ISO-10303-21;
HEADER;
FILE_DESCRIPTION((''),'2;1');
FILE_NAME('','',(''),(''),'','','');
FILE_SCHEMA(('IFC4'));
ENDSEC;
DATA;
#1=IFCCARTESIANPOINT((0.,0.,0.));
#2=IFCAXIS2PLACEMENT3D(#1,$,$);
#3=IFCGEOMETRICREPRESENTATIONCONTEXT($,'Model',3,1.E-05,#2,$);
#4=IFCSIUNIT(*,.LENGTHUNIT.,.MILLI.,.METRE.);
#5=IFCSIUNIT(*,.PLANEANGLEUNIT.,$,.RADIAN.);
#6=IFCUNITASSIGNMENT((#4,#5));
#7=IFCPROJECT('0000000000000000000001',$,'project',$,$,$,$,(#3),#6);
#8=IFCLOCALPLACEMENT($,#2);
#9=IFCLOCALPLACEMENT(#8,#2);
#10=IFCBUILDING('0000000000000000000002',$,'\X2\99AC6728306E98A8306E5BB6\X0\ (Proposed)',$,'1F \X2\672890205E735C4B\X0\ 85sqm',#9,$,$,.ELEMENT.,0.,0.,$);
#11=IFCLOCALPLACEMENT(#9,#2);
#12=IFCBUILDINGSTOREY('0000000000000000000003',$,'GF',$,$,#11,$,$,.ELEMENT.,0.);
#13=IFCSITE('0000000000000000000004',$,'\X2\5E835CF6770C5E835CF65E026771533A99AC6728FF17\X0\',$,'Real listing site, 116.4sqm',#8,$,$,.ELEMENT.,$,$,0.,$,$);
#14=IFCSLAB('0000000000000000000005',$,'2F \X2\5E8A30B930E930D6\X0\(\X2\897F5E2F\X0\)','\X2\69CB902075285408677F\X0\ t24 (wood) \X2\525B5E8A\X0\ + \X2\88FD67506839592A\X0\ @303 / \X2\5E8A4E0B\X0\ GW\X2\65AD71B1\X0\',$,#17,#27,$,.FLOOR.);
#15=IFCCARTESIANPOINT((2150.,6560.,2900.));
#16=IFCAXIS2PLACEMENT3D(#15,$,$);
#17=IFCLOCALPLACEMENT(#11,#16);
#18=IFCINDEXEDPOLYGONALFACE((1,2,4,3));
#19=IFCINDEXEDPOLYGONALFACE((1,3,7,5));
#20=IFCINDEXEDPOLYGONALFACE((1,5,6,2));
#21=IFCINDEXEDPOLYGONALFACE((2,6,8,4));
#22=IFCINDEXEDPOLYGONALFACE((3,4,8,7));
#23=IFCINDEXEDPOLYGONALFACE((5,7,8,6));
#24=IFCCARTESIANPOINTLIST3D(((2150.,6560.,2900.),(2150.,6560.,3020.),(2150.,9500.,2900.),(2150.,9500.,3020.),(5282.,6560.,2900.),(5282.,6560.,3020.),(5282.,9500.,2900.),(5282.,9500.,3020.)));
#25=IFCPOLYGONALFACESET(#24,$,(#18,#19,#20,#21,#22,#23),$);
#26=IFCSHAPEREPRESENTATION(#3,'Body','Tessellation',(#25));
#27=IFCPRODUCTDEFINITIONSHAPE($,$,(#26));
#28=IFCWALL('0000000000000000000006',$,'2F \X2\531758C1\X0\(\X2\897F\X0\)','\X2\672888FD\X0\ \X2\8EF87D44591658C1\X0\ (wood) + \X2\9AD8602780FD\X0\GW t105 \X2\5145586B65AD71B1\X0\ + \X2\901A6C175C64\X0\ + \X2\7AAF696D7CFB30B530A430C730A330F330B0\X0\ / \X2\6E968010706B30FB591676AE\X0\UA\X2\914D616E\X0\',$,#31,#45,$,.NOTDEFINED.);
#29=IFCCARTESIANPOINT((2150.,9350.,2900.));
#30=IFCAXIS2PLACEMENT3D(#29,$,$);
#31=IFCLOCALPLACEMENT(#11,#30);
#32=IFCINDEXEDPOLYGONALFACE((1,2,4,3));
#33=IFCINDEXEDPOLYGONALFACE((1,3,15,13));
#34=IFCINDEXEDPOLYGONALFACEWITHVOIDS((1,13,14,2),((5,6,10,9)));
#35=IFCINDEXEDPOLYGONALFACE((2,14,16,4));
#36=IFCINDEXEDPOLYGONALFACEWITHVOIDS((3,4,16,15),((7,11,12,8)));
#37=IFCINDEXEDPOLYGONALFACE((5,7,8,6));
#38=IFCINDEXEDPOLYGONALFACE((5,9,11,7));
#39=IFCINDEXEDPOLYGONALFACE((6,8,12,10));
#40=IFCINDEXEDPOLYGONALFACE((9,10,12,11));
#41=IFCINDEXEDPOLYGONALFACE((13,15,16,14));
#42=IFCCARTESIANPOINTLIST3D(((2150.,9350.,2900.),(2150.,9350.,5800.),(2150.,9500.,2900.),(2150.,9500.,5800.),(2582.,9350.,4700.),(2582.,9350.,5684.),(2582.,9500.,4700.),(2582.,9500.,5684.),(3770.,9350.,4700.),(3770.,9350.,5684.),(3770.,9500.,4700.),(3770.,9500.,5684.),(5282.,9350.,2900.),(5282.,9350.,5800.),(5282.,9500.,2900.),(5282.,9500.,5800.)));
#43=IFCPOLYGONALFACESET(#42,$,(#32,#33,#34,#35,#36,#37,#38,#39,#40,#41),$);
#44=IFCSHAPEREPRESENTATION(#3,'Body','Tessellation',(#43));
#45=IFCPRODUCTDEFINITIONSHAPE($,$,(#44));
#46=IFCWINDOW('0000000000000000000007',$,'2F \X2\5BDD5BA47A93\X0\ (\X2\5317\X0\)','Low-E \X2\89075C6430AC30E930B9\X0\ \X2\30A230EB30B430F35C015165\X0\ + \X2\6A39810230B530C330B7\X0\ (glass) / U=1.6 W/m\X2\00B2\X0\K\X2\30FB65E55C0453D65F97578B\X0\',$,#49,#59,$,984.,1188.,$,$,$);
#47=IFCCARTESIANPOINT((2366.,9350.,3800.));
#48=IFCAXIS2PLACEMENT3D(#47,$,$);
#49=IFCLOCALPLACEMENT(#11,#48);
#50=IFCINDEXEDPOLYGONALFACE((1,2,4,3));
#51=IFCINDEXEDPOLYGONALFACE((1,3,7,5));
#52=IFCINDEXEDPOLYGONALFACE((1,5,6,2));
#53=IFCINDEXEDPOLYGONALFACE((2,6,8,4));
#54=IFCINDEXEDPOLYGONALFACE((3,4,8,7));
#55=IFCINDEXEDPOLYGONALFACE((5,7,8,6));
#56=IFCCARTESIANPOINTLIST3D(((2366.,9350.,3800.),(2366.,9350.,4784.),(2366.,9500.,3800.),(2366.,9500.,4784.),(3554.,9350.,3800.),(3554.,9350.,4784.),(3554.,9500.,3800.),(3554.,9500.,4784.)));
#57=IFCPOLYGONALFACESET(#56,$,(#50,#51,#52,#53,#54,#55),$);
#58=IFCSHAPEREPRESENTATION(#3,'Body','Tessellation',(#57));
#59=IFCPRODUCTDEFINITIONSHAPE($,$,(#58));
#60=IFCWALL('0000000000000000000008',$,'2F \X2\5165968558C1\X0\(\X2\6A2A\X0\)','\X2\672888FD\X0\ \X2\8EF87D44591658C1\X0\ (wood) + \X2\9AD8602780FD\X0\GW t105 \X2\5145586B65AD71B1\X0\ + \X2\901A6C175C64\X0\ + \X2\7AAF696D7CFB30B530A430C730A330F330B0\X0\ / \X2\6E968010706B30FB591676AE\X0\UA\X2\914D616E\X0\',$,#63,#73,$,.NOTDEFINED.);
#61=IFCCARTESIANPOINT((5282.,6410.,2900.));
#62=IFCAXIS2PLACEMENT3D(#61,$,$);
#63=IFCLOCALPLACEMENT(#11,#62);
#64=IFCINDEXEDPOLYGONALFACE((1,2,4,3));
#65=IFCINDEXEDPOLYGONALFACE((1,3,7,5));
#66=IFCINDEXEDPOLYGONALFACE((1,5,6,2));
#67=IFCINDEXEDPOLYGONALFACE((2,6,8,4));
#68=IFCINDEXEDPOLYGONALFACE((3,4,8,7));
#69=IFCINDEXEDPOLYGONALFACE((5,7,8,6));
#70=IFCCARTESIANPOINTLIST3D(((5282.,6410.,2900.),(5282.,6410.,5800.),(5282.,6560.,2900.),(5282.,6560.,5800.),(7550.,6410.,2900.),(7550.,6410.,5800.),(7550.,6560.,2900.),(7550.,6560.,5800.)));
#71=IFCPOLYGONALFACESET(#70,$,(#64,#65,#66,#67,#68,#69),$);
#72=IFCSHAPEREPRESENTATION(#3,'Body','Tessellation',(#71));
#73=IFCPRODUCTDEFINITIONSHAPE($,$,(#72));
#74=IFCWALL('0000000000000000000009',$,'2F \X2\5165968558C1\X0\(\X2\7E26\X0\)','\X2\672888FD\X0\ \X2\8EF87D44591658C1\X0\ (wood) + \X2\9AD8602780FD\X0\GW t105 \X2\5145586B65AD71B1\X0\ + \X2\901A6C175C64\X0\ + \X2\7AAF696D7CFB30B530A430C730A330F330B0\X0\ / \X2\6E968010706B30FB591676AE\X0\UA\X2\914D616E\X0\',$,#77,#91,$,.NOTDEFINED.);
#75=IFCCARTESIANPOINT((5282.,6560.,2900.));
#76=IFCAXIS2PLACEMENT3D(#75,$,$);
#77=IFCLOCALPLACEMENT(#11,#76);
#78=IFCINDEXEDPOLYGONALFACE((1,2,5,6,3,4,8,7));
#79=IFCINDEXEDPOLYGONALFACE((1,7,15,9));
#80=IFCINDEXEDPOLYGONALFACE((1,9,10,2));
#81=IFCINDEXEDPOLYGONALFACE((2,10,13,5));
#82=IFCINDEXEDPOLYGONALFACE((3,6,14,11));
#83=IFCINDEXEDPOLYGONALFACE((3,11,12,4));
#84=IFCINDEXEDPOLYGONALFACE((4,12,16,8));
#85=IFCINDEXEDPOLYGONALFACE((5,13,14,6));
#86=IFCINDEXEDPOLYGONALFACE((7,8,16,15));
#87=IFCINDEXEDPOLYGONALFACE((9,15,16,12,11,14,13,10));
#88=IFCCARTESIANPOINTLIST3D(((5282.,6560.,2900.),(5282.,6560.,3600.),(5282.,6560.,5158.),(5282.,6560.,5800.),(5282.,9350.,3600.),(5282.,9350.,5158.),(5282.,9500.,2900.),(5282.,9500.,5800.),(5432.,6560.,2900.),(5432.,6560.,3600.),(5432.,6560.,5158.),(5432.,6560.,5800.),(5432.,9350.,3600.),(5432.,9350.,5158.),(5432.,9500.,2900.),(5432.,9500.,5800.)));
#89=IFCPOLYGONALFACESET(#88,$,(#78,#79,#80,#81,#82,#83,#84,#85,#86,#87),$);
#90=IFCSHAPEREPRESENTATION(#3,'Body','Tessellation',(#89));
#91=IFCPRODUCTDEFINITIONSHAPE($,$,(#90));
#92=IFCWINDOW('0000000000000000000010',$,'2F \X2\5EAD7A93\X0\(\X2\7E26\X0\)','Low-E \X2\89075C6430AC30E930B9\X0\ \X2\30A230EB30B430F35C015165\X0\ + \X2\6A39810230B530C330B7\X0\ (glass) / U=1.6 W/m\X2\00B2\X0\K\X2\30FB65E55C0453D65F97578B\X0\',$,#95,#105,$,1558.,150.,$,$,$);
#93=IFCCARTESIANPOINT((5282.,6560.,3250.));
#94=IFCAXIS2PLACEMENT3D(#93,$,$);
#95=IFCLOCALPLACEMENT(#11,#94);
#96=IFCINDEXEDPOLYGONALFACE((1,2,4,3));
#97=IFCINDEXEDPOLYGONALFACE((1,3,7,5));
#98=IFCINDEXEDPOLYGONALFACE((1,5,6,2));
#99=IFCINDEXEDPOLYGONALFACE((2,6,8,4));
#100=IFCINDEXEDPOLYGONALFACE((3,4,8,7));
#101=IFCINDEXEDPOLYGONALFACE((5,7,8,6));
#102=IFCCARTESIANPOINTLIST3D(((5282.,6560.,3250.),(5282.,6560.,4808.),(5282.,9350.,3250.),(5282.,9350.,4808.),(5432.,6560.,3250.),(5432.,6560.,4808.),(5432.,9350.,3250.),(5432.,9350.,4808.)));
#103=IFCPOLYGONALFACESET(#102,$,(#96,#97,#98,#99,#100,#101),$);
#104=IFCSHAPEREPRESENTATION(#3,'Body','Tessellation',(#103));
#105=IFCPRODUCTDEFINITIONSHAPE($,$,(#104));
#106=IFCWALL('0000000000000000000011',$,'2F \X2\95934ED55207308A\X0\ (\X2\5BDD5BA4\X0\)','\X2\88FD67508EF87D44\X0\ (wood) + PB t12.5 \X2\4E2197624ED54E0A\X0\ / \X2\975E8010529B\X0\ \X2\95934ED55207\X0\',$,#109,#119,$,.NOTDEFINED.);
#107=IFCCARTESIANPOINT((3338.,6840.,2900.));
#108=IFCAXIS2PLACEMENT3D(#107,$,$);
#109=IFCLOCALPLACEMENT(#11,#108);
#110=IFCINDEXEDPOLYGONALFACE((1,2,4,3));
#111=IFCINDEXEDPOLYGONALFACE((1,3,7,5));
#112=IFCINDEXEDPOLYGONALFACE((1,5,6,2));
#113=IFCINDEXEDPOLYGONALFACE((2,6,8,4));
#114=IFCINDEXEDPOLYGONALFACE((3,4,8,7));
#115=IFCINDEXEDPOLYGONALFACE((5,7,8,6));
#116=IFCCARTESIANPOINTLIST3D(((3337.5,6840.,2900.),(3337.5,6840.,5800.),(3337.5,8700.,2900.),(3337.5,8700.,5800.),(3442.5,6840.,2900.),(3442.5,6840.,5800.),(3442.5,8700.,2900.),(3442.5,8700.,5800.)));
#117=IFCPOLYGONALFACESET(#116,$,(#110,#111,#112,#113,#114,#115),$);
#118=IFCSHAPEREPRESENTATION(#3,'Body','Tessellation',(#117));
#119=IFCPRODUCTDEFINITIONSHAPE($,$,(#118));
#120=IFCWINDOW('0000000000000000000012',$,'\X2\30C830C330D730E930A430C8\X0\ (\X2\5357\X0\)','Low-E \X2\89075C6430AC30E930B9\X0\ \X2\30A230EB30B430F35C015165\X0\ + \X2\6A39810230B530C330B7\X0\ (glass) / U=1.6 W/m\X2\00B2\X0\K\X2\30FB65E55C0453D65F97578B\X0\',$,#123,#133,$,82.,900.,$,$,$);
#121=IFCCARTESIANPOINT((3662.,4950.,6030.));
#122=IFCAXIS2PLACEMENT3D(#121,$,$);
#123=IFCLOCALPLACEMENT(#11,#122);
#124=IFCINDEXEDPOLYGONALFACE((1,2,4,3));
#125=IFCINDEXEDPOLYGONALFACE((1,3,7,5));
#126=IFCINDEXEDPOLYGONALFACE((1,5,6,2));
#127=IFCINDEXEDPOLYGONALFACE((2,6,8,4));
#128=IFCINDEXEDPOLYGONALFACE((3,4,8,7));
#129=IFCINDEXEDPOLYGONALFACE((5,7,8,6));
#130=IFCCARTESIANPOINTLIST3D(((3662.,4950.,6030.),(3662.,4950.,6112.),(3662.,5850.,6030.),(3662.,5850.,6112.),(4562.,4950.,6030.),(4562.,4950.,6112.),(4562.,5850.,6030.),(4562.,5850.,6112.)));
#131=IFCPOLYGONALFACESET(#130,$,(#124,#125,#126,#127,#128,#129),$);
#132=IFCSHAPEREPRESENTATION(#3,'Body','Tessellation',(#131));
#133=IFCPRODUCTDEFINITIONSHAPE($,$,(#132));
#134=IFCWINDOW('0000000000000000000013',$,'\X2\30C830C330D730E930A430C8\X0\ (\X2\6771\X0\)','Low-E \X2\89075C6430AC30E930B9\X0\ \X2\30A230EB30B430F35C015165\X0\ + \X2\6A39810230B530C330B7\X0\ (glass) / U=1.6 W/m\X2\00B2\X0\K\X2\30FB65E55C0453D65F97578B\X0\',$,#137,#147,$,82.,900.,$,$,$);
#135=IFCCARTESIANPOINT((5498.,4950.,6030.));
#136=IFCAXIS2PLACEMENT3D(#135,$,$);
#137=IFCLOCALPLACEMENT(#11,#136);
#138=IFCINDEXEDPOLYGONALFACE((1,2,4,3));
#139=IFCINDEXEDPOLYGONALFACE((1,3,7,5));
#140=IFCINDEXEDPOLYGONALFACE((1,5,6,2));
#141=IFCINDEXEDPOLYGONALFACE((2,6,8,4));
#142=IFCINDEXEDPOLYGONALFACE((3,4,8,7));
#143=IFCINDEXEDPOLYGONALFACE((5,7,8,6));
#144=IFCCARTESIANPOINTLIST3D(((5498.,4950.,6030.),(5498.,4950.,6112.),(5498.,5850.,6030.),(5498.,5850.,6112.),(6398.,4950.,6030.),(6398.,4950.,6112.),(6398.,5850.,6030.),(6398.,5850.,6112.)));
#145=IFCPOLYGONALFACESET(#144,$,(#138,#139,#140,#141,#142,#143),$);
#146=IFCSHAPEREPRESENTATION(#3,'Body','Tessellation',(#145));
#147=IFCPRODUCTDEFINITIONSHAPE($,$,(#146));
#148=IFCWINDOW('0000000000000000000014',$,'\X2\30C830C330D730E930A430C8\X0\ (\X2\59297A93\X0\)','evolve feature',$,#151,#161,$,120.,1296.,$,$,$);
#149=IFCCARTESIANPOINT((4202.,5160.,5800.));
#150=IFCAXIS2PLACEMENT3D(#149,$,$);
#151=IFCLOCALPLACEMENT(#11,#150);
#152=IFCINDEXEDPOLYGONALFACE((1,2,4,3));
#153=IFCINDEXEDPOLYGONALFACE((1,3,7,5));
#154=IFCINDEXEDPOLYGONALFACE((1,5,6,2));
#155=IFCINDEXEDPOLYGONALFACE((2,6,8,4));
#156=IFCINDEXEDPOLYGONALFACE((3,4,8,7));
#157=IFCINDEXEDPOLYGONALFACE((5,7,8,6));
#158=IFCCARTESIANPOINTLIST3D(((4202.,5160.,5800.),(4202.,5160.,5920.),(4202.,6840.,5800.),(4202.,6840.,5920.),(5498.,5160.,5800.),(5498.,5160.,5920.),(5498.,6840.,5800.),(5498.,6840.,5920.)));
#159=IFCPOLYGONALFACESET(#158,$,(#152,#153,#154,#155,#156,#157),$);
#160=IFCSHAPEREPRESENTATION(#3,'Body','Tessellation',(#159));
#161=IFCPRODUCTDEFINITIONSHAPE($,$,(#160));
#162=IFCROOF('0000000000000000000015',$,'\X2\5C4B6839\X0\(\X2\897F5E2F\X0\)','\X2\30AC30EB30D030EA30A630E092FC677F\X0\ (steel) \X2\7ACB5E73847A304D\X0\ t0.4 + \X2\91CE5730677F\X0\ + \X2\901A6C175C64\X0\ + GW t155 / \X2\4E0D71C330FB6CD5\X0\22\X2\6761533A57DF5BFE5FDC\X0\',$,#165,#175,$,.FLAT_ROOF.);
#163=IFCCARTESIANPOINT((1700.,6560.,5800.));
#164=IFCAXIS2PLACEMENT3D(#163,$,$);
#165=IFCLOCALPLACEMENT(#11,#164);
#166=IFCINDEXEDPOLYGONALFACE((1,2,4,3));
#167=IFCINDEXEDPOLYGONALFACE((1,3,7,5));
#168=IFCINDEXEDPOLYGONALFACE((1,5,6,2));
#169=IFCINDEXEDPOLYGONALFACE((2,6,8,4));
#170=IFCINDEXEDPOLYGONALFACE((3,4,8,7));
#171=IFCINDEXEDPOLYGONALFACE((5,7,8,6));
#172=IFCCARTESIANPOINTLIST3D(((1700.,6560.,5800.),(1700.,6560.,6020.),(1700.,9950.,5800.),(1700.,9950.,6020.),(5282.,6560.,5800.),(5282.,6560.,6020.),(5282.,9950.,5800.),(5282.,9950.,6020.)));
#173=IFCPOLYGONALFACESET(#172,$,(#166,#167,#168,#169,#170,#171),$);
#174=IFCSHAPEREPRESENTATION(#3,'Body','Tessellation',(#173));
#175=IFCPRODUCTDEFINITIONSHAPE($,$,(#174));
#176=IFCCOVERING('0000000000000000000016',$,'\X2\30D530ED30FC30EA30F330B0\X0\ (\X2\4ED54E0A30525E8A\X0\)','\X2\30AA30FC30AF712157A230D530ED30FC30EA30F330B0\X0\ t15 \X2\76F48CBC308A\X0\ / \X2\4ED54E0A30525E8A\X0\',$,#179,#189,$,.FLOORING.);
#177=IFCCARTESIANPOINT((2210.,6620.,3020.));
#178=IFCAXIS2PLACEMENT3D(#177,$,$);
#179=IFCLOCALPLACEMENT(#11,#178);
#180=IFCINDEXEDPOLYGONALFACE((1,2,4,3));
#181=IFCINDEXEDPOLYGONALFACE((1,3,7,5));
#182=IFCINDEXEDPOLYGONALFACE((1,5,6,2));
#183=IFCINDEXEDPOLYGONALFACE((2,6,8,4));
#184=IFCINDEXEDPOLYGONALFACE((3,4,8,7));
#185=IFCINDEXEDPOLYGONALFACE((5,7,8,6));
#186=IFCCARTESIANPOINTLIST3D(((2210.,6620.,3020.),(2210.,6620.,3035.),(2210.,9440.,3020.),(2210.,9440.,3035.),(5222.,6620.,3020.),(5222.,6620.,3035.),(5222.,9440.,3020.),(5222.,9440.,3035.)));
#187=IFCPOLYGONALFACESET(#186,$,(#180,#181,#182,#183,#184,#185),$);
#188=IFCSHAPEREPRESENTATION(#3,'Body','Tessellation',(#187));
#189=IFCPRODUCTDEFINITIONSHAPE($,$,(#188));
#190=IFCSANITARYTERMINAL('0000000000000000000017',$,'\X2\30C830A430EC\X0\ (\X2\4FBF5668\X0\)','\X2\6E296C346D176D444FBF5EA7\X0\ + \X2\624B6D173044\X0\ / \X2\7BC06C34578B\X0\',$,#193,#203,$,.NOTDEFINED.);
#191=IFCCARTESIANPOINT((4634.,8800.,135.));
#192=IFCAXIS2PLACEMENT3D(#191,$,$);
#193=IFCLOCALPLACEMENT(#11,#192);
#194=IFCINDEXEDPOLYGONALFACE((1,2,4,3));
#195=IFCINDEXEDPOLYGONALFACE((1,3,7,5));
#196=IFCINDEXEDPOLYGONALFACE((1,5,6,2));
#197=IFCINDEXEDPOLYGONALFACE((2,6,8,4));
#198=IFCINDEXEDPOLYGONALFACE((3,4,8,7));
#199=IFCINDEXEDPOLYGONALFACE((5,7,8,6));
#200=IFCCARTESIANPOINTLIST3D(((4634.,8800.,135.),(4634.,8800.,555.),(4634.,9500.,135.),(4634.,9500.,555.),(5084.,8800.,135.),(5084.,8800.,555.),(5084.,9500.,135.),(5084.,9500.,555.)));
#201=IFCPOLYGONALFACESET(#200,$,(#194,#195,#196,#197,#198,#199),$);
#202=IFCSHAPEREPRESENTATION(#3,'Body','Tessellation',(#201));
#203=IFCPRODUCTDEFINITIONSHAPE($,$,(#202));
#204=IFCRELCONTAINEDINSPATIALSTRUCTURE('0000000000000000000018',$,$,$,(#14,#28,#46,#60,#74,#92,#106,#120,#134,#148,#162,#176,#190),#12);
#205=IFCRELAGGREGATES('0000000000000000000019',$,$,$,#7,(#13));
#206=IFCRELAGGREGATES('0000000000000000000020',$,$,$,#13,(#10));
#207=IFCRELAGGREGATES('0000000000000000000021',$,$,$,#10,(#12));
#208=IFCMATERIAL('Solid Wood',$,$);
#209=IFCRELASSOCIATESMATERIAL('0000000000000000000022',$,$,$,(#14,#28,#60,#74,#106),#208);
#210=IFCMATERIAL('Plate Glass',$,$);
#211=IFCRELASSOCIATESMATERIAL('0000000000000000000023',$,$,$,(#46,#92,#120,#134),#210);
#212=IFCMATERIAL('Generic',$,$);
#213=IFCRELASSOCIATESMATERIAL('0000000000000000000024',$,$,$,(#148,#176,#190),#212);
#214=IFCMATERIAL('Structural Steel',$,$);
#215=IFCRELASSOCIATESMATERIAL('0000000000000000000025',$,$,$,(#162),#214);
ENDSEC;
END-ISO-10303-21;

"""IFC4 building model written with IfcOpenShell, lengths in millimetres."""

from ifc_helpers import new_model, si_unit, frame, frame_2d, origin, place, context, project, spatial, rectangle, extrude, material, element, fill, save


model = new_model("IFC4")

# Units and contexts
model_context = context("Model", 3, precision=1e-05, world=origin())
ifc_project = project(units=[si_unit("LENGTHUNIT", "METRE", prefix="MILLI"), si_unit("PLANEANGLEUNIT", "RADIAN")], contexts=[model_context])

# Site, building, storey
site_placement = place(None, origin())
site = spatial("IfcSite", under=ifc_project, at=site_placement, Name="広島県広島市東区馬木７", ObjectType="Real listing site, 116.4sqm", CompositionType="ELEMENT", RefElevation=0.0)
building_placement = place(site_placement, origin())
building = spatial("IfcBuilding", under=site, at=building_placement, Name="馬木の風の家 (Proposed)", ObjectType="1F 木造平屋 85sqm", CompositionType="ELEMENT", ElevationOfRefHeight=0.0, ElevationOfTerrain=0.0)
storey_placement = place(building_placement, origin())
storey = spatial("IfcBuildingStorey", under=building, at=storey_placement, Name="GF", CompositionType="ELEMENT", Elevation=0.0)

# Slab
ifc_material_1 = material(Name="Solid Wood")
slab_placement = place(storey_placement, frame((2150.0, 6560.0, 2900.0)))
element("IfcSlab", 1, at=slab_placement, inside=storey, material=ifc_material_1, Name="2F 床スラブ(西帯)", Description="構造用合板 t24 (wood) 剛床 + 製材根太 @303 / 床下 GW断熱", PredefinedType="FLOOR", context=model_context, shape_type="SweptSolid", body=[
    extrude(rectangle(XDim=3132.0, YDim=2940.0, at=frame_2d((1566.0, 1470.0))), frame((2150.0, 6560.0, 2900.0)), (0.0, 0.0, 1.0), 120.0),
])

# Wall, opening, window
wall_1_placement = place(storey_placement, frame((2150.0, 9350.0, 2900.0)))
wall_1 = element("IfcWall", 2, at=wall_1_placement, inside=storey, material=ifc_material_1, Name="2F 北壁(西)", Description="木製 軸組外壁 (wood) + 高性能GW t105 充填断熱 + 通気層 + 窯業系サイディング / 準耐火・外皮UA配慮", PredefinedType="NOTDEFINED", context=model_context, shape_type="SweptSolid", body=[
    extrude(rectangle(XDim=3132.0, YDim=150.0, at=frame_2d((1566.0, 75.0))), frame((2150.0, 9350.0, 2900.0)), (0.0, 0.0, 1.0), 2900.0),
])
opening_1_placement = place(storey_placement, frame((2366.0, 9350.0, 3800.0)))
opening_1 = element("IfcOpeningElement", 3, at=opening_1_placement, cuts=wall_1, PredefinedType="NOTDEFINED", context=model_context, shape_type="SweptSolid", body=[
    extrude(rectangle(XDim=1188.0, YDim=150.0, at=frame_2d((594.0, 75.0))), frame((2366.0, 9350.0, 3800.0)), (0.0, 0.0, 1.0), 984.0),
])
ifc_material_2 = material(Name="Plate Glass")
window_1_placement = place(storey_placement, frame((2366.0, 9350.0, 3800.0)))
window_1 = element("IfcWindow", 4, at=window_1_placement, inside=storey, material=ifc_material_2, Name="2F 寝室窓 (北)", Description="Low-E 複層ガラス アルゴン封入 + 樹脂サッシ (glass) / U=1.6 W/m²K・日射取得型", OverallHeight=984.0, OverallWidth=1188.0, context=model_context, shape_type="SweptSolid", body=[
    extrude(rectangle(XDim=1188.0, YDim=150.0, at=frame_2d((594.0, 75.0))), frame((2366.0, 9350.0, 3800.0)), (0.0, 0.0, 1.0), 984.0),
])
fill(opening_1, window_1)

# Wall
wall_2_placement = place(storey_placement, frame((5282.0, 6410.0, 2900.0)))
element("IfcWall", 5, at=wall_2_placement, inside=storey, material=ifc_material_1, Name="2F 入隅壁(横)", Description="木製 軸組外壁 (wood) + 高性能GW t105 充填断熱 + 通気層 + 窯業系サイディング / 準耐火・外皮UA配慮", PredefinedType="NOTDEFINED", context=model_context, shape_type="SweptSolid", body=[
    extrude(rectangle(XDim=2268.0, YDim=150.0, at=frame_2d((1134.0, 75.0))), frame((5282.0, 6410.0, 2900.0)), (0.0, 0.0, 1.0), 2900.0),
])

# Wall, opening, window
wall_3_placement = place(storey_placement, frame((5282.0, 6560.0, 2900.0)))
wall_3 = element("IfcWall", 6, at=wall_3_placement, inside=storey, material=ifc_material_1, Name="2F 入隅壁(縦)", Description="木製 軸組外壁 (wood) + 高性能GW t105 充填断熱 + 通気層 + 窯業系サイディング / 準耐火・外皮UA配慮", PredefinedType="NOTDEFINED", context=model_context, shape_type="SweptSolid", body=[
    extrude(rectangle(XDim=150.0, YDim=2940.0, at=frame_2d((75.0, 1470.0))), frame((5282.0, 6560.0, 2900.0)), (0.0, 0.0, 1.0), 2900.0),
])
opening_2_placement = place(storey_placement, frame((5282.0, 6560.0, 3250.0)))
opening_2 = element("IfcOpeningElement", 7, at=opening_2_placement, cuts=wall_3, PredefinedType="NOTDEFINED", context=model_context, shape_type="SweptSolid", body=[
    extrude(rectangle(XDim=150.0, YDim=2790.0, at=frame_2d((75.0, 1395.0))), frame((5282.0, 6560.0, 3250.0)), (0.0, 0.0, 1.0), 1558.0),
])
window_2_placement = place(storey_placement, frame((5282.0, 6560.0, 3250.0)))
window_2 = element("IfcWindow", 8, at=window_2_placement, inside=storey, material=ifc_material_2, Name="2F 庭窓(縦)", Description="Low-E 複層ガラス アルゴン封入 + 樹脂サッシ (glass) / U=1.6 W/m²K・日射取得型", OverallHeight=1558.0, OverallWidth=150.0, context=model_context, shape_type="SweptSolid", body=[
    extrude(rectangle(XDim=150.0, YDim=2790.0, at=frame_2d((75.0, 1395.0))), frame((5282.0, 6560.0, 3250.0)), (0.0, 0.0, 1.0), 1558.0),
])
fill(opening_2, window_2)

# Wall
wall_4_placement = place(storey_placement, frame((3338.0, 6840.0, 2900.0)))
element("IfcWall", 9, at=wall_4_placement, inside=storey, material=ifc_material_1, Name="2F 間仕切り (寝室)", Description="製材軸組 (wood) + PB t12.5 両面仕上 / 非耐力 間仕切", PredefinedType="NOTDEFINED", context=model_context, shape_type="SweptSolid", body=[
    extrude(rectangle(XDim=105.0, YDim=1860.0, at=frame_2d((52.0, 930.0))), frame((3338.0, 6840.0, 2900.0)), (0.0, 0.0, 1.0), 2900.0),
])

# Windows
window_3_placement = place(storey_placement, frame((3662.0, 4950.0, 6030.0)))
element("IfcWindow", 10, at=window_3_placement, inside=storey, material=ifc_material_2, Name="トップライト (南)", Description="Low-E 複層ガラス アルゴン封入 + 樹脂サッシ (glass) / U=1.6 W/m²K・日射取得型", OverallHeight=82.0, OverallWidth=900.0, context=model_context, shape_type="SweptSolid", body=[
    extrude(rectangle(XDim=900.0, YDim=900.0, at=frame_2d((450.0, 450.0))), frame((3662.0, 4950.0, 6030.0)), (0.0, 0.0, 1.0), 82.0),
])
window_4_placement = place(storey_placement, frame((5498.0, 4950.0, 6030.0)))
element("IfcWindow", 11, at=window_4_placement, inside=storey, material=ifc_material_2, Name="トップライト (東)", Description="Low-E 複層ガラス アルゴン封入 + 樹脂サッシ (glass) / U=1.6 W/m²K・日射取得型", OverallHeight=82.0, OverallWidth=900.0, context=model_context, shape_type="SweptSolid", body=[
    extrude(rectangle(XDim=900.0, YDim=900.0, at=frame_2d((450.0, 450.0))), frame((5498.0, 4950.0, 6030.0)), (0.0, 0.0, 1.0), 82.0),
])
ifc_material_3 = material(Name="Generic")
window_5_placement = place(storey_placement, frame((4202.0, 5160.0, 5800.0)))
element("IfcWindow", 12, at=window_5_placement, inside=storey, material=ifc_material_3, Name="トップライト (天窓)", Description="evolve feature", OverallHeight=120.0, OverallWidth=1296.0, context=model_context, shape_type="SweptSolid", body=[
    extrude(rectangle(XDim=1296.0, YDim=1680.0, at=frame_2d((648.0, 840.0))), frame((4202.0, 5160.0, 5800.0)), (0.0, 0.0, 1.0), 120.0),
])

# Roof
ifc_material_4 = material(Name="Structural Steel")
for number, where, name in (
    (13, (1700.0, 6560.0, 5800.0), "屋根(西帯)"),
):
    element("IfcRoof", number, at=place(storey_placement, frame(where)), inside=storey, material=ifc_material_4, Name=name, Description="ガルバリウム鋼板 (steel) 立平葺き t0.4 + 野地板 + 通気層 + GW t155 / 不燃・法22条区域対応", PredefinedType="FLAT_ROOF", context=model_context, shape_type="SweptSolid", body=[
        extrude(rectangle(XDim=3582.0, YDim=3390.0, at=frame_2d((1791.0, 1695.0))), frame((1700.0, 6560.0, 5800.0)), (0.0, 0.0, 1.0), 220.0),
    ])

# Covering
covering_placement = place(storey_placement, frame((2210.0, 6620.0, 3020.0)))
element("IfcCovering", 14, at=covering_placement, inside=storey, material=ifc_material_3, Name="フローリング (仕上げ床)", Description="オーク無垢フローリング t15 直貼り / 仕上げ床", PredefinedType="FLOORING", context=model_context, shape_type="SweptSolid", body=[
    extrude(rectangle(XDim=3012.0, YDim=2820.0, at=frame_2d((1506.0, 1410.0))), frame((2210.0, 6620.0, 3020.0)), (0.0, 0.0, 1.0), 15.0),
])

# Sanitary terminal
sanitary_terminal_placement = place(storey_placement, frame((4634.0, 8800.0, 135.0)))
element("IfcSanitaryTerminal", 15, at=sanitary_terminal_placement, inside=storey, material=ifc_material_3, Name="トイレ (便器)", Description="温水洗浄便座 + 手洗い / 節水型", PredefinedType="NOTDEFINED", context=model_context, shape_type="SweptSolid", body=[
    extrude(rectangle(XDim=450.0, YDim=700.0, at=frame_2d((225.0, 350.0))), frame((4634.0, 8800.0, 135.0)), (0.0, 0.0, 1.0), 420.0),
])

save(model, "model.ifc")
